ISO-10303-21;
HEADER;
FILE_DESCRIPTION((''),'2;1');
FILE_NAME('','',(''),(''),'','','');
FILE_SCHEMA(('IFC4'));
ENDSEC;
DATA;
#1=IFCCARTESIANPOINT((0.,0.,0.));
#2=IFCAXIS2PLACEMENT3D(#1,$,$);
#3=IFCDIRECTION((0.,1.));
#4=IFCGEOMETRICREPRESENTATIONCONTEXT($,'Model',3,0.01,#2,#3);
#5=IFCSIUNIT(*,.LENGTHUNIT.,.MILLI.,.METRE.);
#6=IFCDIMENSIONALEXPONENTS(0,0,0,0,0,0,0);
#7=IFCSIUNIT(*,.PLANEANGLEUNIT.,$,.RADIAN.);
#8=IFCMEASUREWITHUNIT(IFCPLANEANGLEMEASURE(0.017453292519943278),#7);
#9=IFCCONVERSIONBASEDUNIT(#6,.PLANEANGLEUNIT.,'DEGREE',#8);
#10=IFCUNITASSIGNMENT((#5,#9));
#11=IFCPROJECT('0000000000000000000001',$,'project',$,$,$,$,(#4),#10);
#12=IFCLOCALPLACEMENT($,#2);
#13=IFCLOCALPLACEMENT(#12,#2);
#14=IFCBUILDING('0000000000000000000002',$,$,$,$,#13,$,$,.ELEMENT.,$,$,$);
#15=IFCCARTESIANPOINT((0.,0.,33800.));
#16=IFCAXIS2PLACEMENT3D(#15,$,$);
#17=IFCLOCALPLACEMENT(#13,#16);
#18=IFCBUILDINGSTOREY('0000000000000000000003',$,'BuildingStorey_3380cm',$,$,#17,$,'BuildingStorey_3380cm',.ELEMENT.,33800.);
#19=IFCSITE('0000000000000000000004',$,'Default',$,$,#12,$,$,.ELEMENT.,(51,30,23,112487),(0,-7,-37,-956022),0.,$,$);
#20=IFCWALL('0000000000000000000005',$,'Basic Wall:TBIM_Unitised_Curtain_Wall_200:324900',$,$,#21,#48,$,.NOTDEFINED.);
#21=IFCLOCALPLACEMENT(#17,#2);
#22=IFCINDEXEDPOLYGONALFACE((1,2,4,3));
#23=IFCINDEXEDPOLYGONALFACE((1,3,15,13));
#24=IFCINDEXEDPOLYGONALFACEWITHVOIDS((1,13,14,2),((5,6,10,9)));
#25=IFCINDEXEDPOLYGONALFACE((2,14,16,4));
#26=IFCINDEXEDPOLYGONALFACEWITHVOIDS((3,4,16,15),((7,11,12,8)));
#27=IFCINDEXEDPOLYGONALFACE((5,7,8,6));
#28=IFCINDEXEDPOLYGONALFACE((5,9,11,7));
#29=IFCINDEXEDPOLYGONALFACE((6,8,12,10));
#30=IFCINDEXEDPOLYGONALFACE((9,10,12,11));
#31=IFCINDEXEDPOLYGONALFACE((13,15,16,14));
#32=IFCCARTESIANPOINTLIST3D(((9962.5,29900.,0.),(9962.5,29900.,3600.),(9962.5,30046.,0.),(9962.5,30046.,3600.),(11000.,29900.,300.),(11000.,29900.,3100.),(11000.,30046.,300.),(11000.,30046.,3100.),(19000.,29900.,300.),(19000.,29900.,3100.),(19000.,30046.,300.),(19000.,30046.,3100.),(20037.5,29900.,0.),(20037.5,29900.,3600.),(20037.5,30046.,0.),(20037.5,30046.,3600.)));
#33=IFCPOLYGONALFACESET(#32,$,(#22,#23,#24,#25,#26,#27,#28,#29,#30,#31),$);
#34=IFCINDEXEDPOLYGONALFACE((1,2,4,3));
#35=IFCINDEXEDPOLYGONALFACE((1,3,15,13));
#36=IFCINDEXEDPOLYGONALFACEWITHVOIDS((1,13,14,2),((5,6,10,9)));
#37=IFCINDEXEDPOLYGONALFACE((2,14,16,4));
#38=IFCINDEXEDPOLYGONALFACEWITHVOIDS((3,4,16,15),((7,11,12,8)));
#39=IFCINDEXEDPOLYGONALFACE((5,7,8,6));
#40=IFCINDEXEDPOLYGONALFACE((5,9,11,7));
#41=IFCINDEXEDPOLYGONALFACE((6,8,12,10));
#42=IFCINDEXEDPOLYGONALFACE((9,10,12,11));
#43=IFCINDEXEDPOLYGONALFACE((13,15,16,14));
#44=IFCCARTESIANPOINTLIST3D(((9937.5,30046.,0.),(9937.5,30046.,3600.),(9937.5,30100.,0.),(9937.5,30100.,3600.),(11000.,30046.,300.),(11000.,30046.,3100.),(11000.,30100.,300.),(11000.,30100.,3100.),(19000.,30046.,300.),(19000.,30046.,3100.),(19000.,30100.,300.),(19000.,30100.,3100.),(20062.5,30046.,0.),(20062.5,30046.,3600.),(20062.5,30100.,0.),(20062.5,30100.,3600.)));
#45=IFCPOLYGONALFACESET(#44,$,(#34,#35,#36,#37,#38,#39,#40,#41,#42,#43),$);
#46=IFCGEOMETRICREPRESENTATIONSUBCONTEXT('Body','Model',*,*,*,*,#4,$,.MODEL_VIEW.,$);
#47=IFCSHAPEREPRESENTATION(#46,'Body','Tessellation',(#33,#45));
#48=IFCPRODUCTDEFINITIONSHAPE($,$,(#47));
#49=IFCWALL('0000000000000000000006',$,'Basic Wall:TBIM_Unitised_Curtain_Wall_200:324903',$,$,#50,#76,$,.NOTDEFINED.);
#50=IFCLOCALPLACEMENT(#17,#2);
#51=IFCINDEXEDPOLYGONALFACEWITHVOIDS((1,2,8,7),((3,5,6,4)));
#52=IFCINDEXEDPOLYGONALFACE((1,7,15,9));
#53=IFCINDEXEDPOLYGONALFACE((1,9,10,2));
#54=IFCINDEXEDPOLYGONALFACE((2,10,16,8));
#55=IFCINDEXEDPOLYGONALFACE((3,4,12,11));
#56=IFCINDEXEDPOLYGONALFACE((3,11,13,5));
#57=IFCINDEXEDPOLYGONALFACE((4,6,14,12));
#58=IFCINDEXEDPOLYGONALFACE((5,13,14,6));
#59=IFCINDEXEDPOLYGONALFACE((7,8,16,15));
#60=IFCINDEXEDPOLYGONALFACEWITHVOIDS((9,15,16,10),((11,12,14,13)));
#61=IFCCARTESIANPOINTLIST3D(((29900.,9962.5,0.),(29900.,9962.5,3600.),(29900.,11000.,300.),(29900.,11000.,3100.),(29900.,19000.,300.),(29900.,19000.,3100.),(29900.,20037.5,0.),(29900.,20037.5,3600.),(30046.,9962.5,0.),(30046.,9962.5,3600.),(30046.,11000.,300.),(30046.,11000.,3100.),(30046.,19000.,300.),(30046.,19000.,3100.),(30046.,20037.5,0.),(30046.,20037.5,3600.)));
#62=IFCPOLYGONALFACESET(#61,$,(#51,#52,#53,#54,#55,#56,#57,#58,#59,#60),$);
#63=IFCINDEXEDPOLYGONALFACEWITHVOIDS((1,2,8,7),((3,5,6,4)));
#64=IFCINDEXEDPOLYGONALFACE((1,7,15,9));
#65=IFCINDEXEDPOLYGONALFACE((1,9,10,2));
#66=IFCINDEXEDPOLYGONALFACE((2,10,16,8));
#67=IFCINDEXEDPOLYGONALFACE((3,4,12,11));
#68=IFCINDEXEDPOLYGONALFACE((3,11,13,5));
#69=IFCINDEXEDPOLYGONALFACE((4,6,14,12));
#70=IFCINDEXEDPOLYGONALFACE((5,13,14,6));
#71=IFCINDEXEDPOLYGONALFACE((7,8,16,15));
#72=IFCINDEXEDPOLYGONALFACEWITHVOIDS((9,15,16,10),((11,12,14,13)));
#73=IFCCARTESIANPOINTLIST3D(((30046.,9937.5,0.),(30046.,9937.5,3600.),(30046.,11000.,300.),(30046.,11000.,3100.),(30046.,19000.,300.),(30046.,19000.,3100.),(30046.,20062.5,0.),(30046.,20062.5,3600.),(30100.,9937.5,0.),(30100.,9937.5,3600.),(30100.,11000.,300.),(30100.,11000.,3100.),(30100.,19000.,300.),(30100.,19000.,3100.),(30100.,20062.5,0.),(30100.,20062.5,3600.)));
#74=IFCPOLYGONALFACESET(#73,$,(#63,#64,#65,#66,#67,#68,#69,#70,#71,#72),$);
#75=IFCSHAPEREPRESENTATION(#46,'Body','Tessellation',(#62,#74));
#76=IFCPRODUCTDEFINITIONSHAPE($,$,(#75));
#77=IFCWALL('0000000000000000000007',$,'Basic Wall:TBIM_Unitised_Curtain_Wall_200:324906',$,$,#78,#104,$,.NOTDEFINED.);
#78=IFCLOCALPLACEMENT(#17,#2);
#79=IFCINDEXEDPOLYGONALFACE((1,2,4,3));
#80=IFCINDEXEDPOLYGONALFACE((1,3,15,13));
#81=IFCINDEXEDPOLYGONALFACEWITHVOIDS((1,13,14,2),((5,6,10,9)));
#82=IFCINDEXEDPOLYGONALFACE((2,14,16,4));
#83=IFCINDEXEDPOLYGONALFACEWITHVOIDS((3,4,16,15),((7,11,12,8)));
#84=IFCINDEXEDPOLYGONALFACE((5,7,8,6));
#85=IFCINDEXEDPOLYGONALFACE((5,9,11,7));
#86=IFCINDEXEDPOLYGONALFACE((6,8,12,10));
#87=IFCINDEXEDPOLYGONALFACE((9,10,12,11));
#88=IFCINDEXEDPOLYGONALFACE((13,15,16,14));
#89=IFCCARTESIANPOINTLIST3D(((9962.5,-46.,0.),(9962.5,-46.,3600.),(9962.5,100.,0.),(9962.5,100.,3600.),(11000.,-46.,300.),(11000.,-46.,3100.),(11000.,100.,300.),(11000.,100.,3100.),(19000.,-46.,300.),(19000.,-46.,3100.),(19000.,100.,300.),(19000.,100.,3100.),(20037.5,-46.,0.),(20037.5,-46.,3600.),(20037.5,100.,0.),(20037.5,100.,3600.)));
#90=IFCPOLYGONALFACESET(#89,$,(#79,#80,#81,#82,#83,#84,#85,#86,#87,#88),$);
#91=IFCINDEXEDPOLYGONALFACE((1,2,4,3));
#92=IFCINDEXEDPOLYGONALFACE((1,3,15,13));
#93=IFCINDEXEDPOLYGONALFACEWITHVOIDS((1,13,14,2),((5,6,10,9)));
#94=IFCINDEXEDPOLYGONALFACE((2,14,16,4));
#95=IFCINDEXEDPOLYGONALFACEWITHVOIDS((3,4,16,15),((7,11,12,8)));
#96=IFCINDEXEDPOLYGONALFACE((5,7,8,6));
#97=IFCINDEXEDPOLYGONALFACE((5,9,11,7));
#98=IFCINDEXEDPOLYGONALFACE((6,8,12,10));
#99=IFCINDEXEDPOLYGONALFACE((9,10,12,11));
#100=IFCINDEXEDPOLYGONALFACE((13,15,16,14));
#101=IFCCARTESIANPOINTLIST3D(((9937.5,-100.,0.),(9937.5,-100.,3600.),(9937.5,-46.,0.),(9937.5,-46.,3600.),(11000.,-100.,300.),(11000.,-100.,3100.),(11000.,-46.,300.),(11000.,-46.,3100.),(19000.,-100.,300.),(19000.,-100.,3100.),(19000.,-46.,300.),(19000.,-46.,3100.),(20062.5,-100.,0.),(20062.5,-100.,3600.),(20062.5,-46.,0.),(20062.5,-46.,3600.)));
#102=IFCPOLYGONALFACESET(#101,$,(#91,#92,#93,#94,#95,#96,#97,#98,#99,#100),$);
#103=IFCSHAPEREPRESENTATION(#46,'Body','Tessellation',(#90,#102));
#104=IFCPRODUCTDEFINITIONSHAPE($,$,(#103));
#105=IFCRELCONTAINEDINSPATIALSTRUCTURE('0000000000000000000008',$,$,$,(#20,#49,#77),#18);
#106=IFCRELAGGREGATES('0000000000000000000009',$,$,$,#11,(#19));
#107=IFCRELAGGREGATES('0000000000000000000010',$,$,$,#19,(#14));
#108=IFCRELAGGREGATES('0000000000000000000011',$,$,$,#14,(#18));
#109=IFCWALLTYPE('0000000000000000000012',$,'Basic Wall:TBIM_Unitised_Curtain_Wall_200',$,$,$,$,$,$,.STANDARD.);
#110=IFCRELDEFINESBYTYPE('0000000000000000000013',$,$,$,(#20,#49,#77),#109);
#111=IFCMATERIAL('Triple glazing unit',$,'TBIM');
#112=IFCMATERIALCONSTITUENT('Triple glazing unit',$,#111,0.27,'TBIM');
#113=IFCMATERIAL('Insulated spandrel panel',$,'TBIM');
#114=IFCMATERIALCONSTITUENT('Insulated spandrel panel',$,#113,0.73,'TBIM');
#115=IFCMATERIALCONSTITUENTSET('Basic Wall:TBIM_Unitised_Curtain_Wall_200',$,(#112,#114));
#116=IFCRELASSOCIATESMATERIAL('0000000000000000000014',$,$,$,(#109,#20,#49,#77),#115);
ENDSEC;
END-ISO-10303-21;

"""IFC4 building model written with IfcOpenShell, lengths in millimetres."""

from ifc_helpers import new_model, entity, si_unit, converted_unit, direction, frame, origin, place, context, subcontext, project, spatial, indexed_curve, outline, extrude, material, constituent, constituent_set, type_object, element, save


model = new_model("IFC4")

# Units and contexts
model_context = context("Model", 3, precision=0.01, world=origin(), true_north=direction((0.0, 1.0)))
body_context = subcontext(model_context, "Body", "Model", "MODEL_VIEW")
ifc_project = project(units=[si_unit("LENGTHUNIT", "METRE", prefix="MILLI"), converted_unit("PLANEANGLEUNIT", "DEGREE", entity("IfcPlaneAngleMeasure", 0.017453292519943278), si_unit("PLANEANGLEUNIT", "RADIAN"), dimensions=[0, 0, 0, 0, 0, 0, 0])], contexts=[model_context])

# Site, building, storey
site_placement = place(None, origin())
site = spatial("IfcSite", under=ifc_project, at=site_placement, Name="Default", CompositionType="ELEMENT", RefLatitude=(51, 30, 23, 112487), RefLongitude=(0, -7, -37, -956022), RefElevation=0.0)
building_placement = place(site_placement, origin())
building = spatial("IfcBuilding", under=site, at=building_placement, CompositionType="ELEMENT")
storey_placement = place(building_placement, frame((0.0, 0.0, 33800.0)))
storey = spatial("IfcBuildingStorey", under=building, at=storey_placement, Name="BuildingStorey_3380cm", LongName="BuildingStorey_3380cm", CompositionType="ELEMENT", Elevation=33800.0)

# Walls, openings
ifc_material_1 = material(Name="Triple glazing unit", Category="TBIM")
ifc_constituent_1 = constituent(ifc_material_1, Name="Triple glazing unit", Category="TBIM", fraction=0.27)
ifc_material_2 = material(Name="Insulated spandrel panel", Category="TBIM")
ifc_constituent_2 = constituent(ifc_material_2, Name="Insulated spandrel panel", Category="TBIM", fraction=0.73)
ifc_constituent_set_1 = constituent_set(constituents=[ifc_constituent_1, ifc_constituent_2], Name="Basic Wall:TBIM_Unitised_Curtain_Wall_200")
wall_type_1 = type_object("IfcWallType", Name="Basic Wall:TBIM_Unitised_Curtain_Wall_200", PredefinedType="STANDARD", material=ifc_constituent_set_1)
wall_1_placement = place(storey_placement, frame((9937.5, 30000.0, 0.0)))
wall_1 = element("IfcWall", 1, at=wall_1_placement, inside=storey, type_object=wall_type_1, material=ifc_constituent_set_1, Name="Basic Wall:TBIM_Unitised_Curtain_Wall_200:324900", PredefinedType="NOTDEFINED", context=body_context, shape_type="SweptSolid", body=[
    extrude(outline(indexed_curve([(-1800.0, -5037.5), (1800.0, -5037.5), (1800.0, -4937.5), (1800.0, 4937.5), (1800.0, 5037.5), (-1800.0, 5037.5), (-1800.0, 4937.5), (-1800.0, -4937.5), (-1800.0, -5037.5)], self_intersect=False), holes=[indexed_curve([(1300.0, -4000.0), (-1500.0, -4000.0), (-1500.0, 4000.0), (1300.0, 4000.0), (1300.0, -4000.0)], self_intersect=False)]), frame((5062.5, -100.0, 1800.0), z_axis=(0.0, 1.0, 0.0), x_axis=(0.0, 0.0, 1.0)), (0.0, 0.0, 1.0), 146.0),
    extrude(outline(indexed_curve([(-1800.0, -5062.5), (1800.0, -5062.5), (1800.0, 5062.5), (-1800.0, 5062.5), (-1800.0, -5062.5)], self_intersect=False), holes=[indexed_curve([(-1500.0, -4000.0), (-1500.0, 4000.0), (1300.0, 4000.0), (1300.0, -4000.0), (-1500.0, -4000.0)], self_intersect=False)]), frame((5062.5, 46.0, 1800.0), z_axis=(0.0, 1.0, 0.0), x_axis=(0.0, 0.0, 1.0)), (0.0, 0.0, 1.0), 54.0),
])
opening_1_placement = place(wall_1_placement, frame((1062.5, -100.0, 300.0)))
element("IfcOpeningElement", 2, at=opening_1_placement, cuts=wall_1, PredefinedType="OPENING", context=body_context, shape_type="SweptSolid", body=[
    extrude(outline(indexed_curve([(2800.0, 0.0), (2800.0, 8000.0), (0.0, 8000.0), (0.0, 0.0), (2800.0, 0.0)], self_intersect=False)), frame((0.0, 0.0, 0.0), z_axis=(0.0, 1.0, 0.0), x_axis=(0.0, 0.0, 1.0)), (0.0, 0.0, 1.0), 200.0),
])
wall_2_placement = place(storey_placement, frame((30000.0, 9937.5, 0.0), z_axis=(0.0, 0.0, 1.0), x_axis=(0.0, 1.0, 0.0)))
wall_2 = element("IfcWall", 3, at=wall_2_placement, inside=storey, type_object=wall_type_1, material=ifc_constituent_set_1, Name="Basic Wall:TBIM_Unitised_Curtain_Wall_200:324903", PredefinedType="NOTDEFINED", context=body_context, shape_type="SweptSolid", body=[
    extrude(outline(indexed_curve([(-5037.5, -1800.0), (-4937.5, -1800.0), (4937.5, -1800.0), (5037.5, -1800.0), (5037.5, 1800.0), (4937.5, 1800.0), (-4937.5, 1800.0), (-5037.5, 1800.0), (-5037.5, -1800.0)], self_intersect=False), holes=[indexed_curve([(-4000.0, 1300.0), (4000.0, 1300.0), (4000.0, -1500.0), (-4000.0, -1500.0), (-4000.0, 1300.0)], self_intersect=False)]), frame((5062.5, 100.0, 1800.0), z_axis=(0.0, -1.0, 0.0), x_axis=(1.0, 0.0, 0.0)), (0.0, 0.0, 1.0), 146.0),
    extrude(outline(indexed_curve([(-1800.0, -5062.5), (1800.0, -5062.5), (1800.0, 5062.5), (-1800.0, 5062.5), (-1800.0, -5062.5)], self_intersect=False), holes=[indexed_curve([(1300.0, 4000.0), (1300.0, -4000.0), (-1500.0, -4000.0), (-1500.0, 4000.0), (1300.0, 4000.0)], self_intersect=False)]), frame((5062.5, -46.0, 1800.0), z_axis=(0.0, -1.0, 0.0), x_axis=(0.0, 0.0, 1.0)), (0.0, 0.0, 1.0), 54.0),
])
opening_2_placement = place(wall_2_placement, frame((1062.5, -100.0, 300.0)))
element("IfcOpeningElement", 4, at=opening_2_placement, cuts=wall_2, PredefinedType="OPENING", context=body_context, shape_type="SweptSolid", body=[
    extrude(outline(indexed_curve([(2800.0, 0.0), (2800.0, 8000.0), (0.0, 8000.0), (0.0, 0.0), (2800.0, 0.0)], self_intersect=False)), frame((0.0, 0.0, 0.0), z_axis=(0.0, 1.0, 0.0), x_axis=(0.0, 0.0, 1.0)), (0.0, 0.0, 1.0), 200.0),
])
wall_3_placement = place(storey_placement, frame((9937.5, 0.0, 0.0)))
wall_3 = element("IfcWall", 5, at=wall_3_placement, inside=storey, type_object=wall_type_1, material=ifc_constituent_set_1, Name="Basic Wall:TBIM_Unitised_Curtain_Wall_200:324906", PredefinedType="NOTDEFINED", context=body_context, shape_type="SweptSolid", body=[
    extrude(outline(indexed_curve([(-1800.0, -5037.5), (1800.0, -5037.5), (1800.0, 5037.5), (-1800.0, 5037.5), (-1800.0, -5037.5)], self_intersect=False), holes=[indexed_curve([(-1500.0, -4000.0), (-1500.0, 4000.0), (1300.0, 4000.0), (1300.0, -4000.0), (-1500.0, -4000.0)], self_intersect=False)]), frame((5062.5, -46.0, 1800.0), z_axis=(0.0, 1.0, 0.0), x_axis=(0.0, 0.0, 1.0)), (0.0, 0.0, 1.0), 146.0),
    extrude(outline(indexed_curve([(-1800.0, -5062.5), (1800.0, -5062.5), (1800.0, 5062.5), (-1800.0, 5062.5), (-1800.0, -5062.5)], self_intersect=False), holes=[indexed_curve([(1300.0, -4000.0), (-1500.0, -4000.0), (-1500.0, 4000.0), (1300.0, 4000.0), (1300.0, -4000.0)], self_intersect=False)]), frame((5062.5, -100.0, 1800.0), z_axis=(0.0, 1.0, 0.0), x_axis=(0.0, 0.0, 1.0)), (0.0, 0.0, 1.0), 54.0),
])
opening_3_placement = place(wall_3_placement, frame((1062.5, -100.0, 300.0)))
element("IfcOpeningElement", 6, at=opening_3_placement, cuts=wall_3, PredefinedType="OPENING", context=body_context, shape_type="SweptSolid", body=[
    extrude(outline(indexed_curve([(2800.0, 0.0), (2800.0, 8000.0), (0.0, 8000.0), (0.0, 0.0), (2800.0, 0.0)], self_intersect=False)), frame((0.0, 0.0, 0.0), z_axis=(0.0, 1.0, 0.0), x_axis=(0.0, 0.0, 1.0)), (0.0, 0.0, 1.0), 200.0),
])

save(model, "model.ifc")
